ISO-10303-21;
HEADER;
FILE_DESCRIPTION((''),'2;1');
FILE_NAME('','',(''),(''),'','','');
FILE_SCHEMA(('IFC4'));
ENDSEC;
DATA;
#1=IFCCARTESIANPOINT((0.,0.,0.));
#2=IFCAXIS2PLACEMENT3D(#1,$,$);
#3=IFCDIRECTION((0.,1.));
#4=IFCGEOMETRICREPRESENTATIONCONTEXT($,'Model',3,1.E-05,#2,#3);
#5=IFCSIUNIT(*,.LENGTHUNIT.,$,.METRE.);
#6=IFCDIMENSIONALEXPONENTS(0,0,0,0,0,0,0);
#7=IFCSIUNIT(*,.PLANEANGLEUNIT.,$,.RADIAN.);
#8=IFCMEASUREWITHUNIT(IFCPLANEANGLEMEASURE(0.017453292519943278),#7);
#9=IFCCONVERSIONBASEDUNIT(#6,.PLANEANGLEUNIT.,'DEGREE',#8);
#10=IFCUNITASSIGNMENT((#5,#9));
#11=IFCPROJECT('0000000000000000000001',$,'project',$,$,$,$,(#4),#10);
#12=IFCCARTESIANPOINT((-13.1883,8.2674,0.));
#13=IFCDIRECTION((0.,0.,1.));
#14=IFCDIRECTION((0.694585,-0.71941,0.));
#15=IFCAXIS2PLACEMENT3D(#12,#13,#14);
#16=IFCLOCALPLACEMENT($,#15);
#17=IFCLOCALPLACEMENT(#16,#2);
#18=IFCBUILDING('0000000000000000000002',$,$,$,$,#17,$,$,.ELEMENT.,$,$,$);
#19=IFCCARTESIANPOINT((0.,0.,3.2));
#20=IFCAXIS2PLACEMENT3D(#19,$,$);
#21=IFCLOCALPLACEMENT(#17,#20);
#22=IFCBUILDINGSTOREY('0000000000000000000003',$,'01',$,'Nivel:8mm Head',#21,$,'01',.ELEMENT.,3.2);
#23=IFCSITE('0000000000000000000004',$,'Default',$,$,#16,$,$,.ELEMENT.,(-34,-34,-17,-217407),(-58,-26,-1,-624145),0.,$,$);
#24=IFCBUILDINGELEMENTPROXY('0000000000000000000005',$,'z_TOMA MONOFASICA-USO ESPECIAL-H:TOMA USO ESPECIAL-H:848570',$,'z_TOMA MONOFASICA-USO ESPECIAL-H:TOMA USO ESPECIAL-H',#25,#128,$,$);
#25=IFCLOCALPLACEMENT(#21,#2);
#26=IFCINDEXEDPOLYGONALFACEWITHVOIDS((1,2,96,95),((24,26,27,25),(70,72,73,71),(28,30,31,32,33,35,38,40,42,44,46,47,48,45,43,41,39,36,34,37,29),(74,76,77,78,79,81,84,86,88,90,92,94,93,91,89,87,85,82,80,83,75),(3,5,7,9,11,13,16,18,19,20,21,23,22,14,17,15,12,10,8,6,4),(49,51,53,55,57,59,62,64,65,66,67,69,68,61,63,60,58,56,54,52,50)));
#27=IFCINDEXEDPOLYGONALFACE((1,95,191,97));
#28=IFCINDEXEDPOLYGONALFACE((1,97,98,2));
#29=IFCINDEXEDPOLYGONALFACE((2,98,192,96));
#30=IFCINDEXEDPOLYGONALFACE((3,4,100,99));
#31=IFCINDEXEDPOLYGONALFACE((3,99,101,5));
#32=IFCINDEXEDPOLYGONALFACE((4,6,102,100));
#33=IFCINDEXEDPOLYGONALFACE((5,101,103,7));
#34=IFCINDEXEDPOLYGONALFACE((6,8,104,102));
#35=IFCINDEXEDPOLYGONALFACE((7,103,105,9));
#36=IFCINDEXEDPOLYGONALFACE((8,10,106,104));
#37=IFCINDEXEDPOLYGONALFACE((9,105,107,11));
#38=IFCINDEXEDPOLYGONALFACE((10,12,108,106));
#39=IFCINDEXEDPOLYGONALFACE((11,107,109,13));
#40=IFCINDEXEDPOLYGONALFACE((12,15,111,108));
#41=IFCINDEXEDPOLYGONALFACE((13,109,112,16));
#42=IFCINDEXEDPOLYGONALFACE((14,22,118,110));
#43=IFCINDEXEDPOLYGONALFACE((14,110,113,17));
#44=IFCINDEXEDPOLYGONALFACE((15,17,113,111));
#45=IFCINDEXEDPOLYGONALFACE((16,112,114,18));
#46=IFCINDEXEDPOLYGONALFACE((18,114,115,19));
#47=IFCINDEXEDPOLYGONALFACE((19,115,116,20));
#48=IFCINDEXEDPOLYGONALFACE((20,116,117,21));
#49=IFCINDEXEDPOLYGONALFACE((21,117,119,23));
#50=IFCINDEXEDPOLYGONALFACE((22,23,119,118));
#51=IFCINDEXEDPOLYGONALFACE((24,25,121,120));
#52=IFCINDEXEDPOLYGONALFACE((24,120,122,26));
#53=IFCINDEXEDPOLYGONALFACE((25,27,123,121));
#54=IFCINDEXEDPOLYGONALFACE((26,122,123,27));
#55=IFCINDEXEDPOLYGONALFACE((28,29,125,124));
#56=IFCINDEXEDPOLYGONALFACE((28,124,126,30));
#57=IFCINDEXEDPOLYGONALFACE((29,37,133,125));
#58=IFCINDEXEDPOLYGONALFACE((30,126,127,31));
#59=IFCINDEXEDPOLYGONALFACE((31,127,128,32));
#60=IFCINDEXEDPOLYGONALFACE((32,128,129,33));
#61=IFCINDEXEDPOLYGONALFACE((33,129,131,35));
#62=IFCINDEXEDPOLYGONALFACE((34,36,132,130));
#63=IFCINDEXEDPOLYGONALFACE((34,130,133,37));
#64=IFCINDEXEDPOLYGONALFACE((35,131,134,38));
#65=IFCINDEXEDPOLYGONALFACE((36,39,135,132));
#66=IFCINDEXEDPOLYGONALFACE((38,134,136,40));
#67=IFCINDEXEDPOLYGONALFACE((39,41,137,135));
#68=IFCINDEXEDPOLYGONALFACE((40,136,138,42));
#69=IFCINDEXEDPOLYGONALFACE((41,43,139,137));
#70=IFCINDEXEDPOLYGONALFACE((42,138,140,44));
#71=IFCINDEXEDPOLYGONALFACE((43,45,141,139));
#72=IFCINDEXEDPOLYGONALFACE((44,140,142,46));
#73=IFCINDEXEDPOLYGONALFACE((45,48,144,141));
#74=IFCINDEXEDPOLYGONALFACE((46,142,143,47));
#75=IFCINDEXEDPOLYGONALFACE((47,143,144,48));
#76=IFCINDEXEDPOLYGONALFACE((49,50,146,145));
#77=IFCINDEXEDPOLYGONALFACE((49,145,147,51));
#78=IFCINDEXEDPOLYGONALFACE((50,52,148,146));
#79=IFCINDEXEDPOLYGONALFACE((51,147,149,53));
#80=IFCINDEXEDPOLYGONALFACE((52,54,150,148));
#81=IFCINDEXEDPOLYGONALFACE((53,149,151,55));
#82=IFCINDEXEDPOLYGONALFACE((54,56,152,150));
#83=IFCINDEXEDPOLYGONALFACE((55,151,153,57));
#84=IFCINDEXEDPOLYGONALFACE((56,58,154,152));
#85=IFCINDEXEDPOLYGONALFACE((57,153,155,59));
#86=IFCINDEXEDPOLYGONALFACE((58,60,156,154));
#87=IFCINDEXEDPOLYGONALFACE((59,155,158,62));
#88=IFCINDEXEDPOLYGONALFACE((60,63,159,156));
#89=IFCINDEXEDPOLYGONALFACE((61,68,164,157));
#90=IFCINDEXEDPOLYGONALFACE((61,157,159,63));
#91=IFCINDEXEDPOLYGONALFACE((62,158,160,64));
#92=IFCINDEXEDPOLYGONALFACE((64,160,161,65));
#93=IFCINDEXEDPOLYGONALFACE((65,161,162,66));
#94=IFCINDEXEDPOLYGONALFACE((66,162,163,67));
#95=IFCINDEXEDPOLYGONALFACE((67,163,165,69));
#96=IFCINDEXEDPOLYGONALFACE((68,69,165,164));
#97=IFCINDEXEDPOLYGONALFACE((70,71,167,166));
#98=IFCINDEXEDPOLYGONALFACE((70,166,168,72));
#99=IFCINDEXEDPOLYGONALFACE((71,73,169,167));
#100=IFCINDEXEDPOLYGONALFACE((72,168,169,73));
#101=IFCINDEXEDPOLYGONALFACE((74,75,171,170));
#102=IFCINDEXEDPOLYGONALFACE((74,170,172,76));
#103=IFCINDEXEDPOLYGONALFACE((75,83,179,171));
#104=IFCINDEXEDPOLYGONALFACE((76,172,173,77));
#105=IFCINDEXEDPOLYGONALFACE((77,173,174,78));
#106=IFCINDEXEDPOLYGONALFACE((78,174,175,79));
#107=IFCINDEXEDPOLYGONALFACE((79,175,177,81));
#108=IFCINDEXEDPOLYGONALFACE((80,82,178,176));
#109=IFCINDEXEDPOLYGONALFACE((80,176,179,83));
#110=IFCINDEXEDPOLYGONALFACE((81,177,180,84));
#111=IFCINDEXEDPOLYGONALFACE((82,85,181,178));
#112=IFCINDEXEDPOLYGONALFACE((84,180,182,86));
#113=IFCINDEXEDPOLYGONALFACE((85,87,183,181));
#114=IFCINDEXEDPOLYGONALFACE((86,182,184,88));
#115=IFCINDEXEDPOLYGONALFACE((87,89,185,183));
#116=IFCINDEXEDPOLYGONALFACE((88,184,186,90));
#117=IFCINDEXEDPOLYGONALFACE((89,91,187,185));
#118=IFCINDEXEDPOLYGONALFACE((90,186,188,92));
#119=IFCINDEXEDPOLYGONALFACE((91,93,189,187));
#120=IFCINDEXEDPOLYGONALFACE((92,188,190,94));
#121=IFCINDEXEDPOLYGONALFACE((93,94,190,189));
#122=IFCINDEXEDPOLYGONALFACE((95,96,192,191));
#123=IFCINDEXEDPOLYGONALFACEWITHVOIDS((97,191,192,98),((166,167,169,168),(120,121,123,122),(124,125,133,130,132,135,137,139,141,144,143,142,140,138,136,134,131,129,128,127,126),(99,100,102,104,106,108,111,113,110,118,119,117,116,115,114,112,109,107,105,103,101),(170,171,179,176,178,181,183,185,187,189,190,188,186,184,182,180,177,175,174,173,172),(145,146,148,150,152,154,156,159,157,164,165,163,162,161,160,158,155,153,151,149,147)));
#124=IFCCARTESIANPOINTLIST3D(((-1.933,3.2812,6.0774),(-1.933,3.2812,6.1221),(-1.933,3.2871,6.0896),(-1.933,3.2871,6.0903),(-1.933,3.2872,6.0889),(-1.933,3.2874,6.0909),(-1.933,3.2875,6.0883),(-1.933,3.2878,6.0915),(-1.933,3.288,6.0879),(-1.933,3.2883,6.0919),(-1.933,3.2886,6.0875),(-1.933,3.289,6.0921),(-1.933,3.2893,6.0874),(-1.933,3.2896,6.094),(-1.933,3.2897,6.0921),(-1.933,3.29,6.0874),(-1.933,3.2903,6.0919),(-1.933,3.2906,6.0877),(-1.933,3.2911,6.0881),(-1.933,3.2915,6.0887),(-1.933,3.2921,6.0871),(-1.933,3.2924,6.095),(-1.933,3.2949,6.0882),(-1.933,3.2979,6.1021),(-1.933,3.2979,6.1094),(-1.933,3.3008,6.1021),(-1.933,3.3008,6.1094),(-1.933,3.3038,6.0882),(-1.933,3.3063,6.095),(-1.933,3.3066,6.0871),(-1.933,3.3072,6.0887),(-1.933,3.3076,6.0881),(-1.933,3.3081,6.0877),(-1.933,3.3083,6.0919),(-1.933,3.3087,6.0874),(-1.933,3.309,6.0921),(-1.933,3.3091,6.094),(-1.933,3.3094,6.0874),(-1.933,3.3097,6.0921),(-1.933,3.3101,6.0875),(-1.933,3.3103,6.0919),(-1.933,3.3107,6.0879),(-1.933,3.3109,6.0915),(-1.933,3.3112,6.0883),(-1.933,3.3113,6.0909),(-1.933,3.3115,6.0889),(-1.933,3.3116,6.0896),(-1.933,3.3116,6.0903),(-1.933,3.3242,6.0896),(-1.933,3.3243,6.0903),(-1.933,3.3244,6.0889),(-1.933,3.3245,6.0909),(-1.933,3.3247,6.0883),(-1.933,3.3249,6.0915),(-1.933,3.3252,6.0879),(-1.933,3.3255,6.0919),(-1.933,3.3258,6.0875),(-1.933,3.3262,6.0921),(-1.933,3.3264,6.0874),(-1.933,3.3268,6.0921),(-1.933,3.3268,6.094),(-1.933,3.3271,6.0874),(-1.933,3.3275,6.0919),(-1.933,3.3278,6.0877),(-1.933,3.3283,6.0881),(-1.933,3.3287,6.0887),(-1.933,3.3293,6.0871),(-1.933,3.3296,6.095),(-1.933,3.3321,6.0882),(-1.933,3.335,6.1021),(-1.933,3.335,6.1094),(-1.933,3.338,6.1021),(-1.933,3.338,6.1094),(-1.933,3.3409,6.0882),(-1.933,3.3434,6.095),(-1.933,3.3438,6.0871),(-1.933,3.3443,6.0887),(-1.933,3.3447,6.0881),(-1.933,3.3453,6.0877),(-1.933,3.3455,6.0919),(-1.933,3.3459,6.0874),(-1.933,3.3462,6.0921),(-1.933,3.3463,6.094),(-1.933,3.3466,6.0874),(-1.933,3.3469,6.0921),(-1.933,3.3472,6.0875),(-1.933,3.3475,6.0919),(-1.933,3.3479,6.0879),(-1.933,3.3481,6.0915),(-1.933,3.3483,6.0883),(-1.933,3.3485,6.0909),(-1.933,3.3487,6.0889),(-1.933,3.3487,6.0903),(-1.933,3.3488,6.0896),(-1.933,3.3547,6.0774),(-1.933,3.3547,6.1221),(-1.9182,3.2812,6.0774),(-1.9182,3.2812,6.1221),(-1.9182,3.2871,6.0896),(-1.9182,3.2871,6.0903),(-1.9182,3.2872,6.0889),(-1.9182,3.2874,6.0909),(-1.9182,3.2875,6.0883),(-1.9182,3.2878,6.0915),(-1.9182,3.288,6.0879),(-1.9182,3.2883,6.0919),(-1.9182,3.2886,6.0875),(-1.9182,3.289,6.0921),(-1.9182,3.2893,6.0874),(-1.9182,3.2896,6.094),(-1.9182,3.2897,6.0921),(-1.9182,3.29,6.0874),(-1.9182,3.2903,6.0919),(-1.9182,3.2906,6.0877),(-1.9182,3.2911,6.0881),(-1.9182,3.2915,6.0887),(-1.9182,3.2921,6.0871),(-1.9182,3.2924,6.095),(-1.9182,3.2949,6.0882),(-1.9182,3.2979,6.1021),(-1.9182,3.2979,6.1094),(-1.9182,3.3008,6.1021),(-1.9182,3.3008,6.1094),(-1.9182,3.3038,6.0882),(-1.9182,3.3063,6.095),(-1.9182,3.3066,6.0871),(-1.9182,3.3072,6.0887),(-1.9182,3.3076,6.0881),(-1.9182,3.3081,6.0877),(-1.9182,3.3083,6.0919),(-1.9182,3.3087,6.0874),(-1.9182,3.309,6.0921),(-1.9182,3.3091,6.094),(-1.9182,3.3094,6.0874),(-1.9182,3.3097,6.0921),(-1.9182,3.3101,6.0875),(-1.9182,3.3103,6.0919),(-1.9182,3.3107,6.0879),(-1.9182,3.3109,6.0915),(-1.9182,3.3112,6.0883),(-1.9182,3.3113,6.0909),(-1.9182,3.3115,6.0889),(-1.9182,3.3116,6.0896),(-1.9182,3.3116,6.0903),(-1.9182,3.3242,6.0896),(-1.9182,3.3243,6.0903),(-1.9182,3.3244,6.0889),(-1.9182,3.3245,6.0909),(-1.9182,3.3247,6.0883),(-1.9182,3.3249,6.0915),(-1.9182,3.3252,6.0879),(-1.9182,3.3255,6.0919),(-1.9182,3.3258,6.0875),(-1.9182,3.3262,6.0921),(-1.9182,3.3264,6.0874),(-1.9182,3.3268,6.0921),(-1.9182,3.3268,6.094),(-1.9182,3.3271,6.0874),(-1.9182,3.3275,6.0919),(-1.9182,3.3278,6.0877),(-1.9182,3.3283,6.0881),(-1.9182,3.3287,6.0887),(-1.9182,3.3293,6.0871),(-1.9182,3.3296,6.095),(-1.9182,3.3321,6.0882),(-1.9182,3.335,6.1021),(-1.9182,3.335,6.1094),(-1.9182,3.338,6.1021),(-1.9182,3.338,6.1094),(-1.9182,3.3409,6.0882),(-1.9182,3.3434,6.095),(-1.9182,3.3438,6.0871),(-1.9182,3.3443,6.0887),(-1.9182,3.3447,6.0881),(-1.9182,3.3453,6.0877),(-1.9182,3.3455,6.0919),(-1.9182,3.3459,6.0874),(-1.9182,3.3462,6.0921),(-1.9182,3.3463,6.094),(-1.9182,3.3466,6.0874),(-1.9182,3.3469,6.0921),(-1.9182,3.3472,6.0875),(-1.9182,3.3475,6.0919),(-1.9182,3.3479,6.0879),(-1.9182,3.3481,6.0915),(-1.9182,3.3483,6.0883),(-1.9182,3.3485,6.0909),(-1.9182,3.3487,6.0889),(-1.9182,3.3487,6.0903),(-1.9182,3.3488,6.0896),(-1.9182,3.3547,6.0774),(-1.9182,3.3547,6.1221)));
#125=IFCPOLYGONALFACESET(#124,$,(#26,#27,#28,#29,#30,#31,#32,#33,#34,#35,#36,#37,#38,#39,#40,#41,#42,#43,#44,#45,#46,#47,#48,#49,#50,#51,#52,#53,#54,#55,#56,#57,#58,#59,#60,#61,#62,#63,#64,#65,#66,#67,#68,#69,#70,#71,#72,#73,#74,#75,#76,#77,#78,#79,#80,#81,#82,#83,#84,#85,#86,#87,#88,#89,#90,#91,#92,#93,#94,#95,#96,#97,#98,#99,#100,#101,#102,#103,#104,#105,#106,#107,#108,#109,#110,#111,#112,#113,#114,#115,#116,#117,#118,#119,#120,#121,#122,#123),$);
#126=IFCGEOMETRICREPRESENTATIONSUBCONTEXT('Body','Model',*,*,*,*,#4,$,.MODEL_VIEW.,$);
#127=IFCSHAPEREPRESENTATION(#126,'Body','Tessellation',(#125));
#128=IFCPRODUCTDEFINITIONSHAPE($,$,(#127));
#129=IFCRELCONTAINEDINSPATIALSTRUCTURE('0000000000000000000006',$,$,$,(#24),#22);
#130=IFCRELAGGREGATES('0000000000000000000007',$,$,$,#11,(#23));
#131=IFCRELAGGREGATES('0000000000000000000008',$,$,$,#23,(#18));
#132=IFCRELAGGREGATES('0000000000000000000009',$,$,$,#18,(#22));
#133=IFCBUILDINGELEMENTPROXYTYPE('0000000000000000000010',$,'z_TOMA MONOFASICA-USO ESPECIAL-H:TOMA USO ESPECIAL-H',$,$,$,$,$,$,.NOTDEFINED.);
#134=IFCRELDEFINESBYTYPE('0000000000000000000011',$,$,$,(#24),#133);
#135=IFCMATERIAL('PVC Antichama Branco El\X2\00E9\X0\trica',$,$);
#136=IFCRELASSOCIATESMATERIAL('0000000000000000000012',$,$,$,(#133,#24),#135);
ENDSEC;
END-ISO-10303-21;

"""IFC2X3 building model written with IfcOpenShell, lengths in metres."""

from ifc_helpers import new_model, entity, si_unit, converted_unit, direction, frame, frame_2d, origin, place, context, subcontext, project, spatial, polyline, circle_curve, parameter, trimmed, segment, composite_curve, outline, extrude, source, transform, mapped, material, type_object, type_shapes, element, save


model = new_model("IFC2X3")

# Units and contexts
model_context = context("Model", 3, precision=1e-05, world=origin(), true_north=direction((0.0, 1.0)))
body_context = subcontext(model_context, "Body", "Model", "MODEL_VIEW")
ifc_project = project(units=[si_unit("LENGTHUNIT", "METRE"), converted_unit("PLANEANGLEUNIT", "DEGREE", entity("IfcPlaneAngleMeasure", 0.017453292519943278), si_unit("PLANEANGLEUNIT", "RADIAN"), dimensions=[0, 0, 0, 0, 0, 0, 0])], contexts=[model_context])

# Site, building, storey
site_placement = place(None, frame((-13.1883, 8.2674, 0.0), z_axis=(0.0, 0.0, 1.0), x_axis=(0.694585, -0.71941, 0.0)))
site = spatial("IfcSite", under=ifc_project, at=site_placement, Name="Default", CompositionType="ELEMENT", RefLatitude=(-34, -34, -17, -217407), RefLongitude=(-58, -26, -1, -624145), RefElevation=0.0)
building_placement = place(site_placement, origin())
building = spatial("IfcBuilding", under=site, at=building_placement, CompositionType="ELEMENT")
storey_placement = place(building_placement, frame((0.0, 0.0, 3.2)))
storey = spatial("IfcBuildingStorey", under=building, at=storey_placement, Name="01", ObjectType="Nivel:8mm Head", LongName="01", CompositionType="ELEMENT", Elevation=3.2)

# Building element proxy
ifc_material_1 = material(Name="PVC Antichama Branco Elétrica")
building_element_proxy_type_1 = type_object("IfcBuildingElementProxyType", Name="z_TOMA MONOFASICA-USO ESPECIAL-H:TOMA USO ESPECIAL-H", PredefinedType="NOTDEFINED", material=ifc_material_1)
shared_shape_1 = source(origin(), body_context, "Body", "SweptSolid", [
    extrude(outline(polyline([(-0.0368, -0.0223), (0.0368, -0.0223), (0.0368, 0.0223), (-0.0368, 0.0223), (-0.0368, -0.0223)]), holes=[composite_curve([segment(polyline([(0.0141, 0.0115), (0.0116, 0.0047)]), True, "CONTINUOUS"), segment(polyline([(0.0116, 0.0047), (0.0088, 0.0057)]), True, "CONTINUOUS"), segment(polyline([(0.0088, 0.0057), (0.0096, 0.0078)]), True, "CONTINUOUS"), segment(trimmed(circle_curve(frame_2d((0.0087, 0.0099), x_axis=(1.0, 0.0)), 0.0024), [parameter(27.118901)], [parameter(292.881099)], True, "PARAMETER"), False, "CONTINUOUS"), segment(polyline([(0.0108, 0.011), (0.0113, 0.0126)]), True, "CONTINUOUS"), segment(polyline([(0.0113, 0.0126), (0.0141, 0.0115)]), True, "CONTINUOUS")], self_intersect=False), composite_curve([segment(polyline([(0.0255, 0.0047), (0.023, 0.0115)]), True, "CONTINUOUS"), segment(polyline([(0.023, 0.0115), (0.0258, 0.0126)]), True, "CONTINUOUS"), segment(polyline([(0.0258, 0.0126), (0.0264, 0.011)]), True, "CONTINUOUS"), segment(trimmed(circle_curve(frame_2d((0.0285, 0.0099), x_axis=(1.0, 0.0)), 0.0024), [parameter(247.118901)], [parameter(152.881099)], True, "PARAMETER"), False, "CONTINUOUS"), segment(polyline([(0.0276, 0.0078), (0.0283, 0.0057)]), True, "CONTINUOUS"), segment(polyline([(0.0283, 0.0057), (0.0255, 0.0047)]), True, "CONTINUOUS")], self_intersect=False), polyline([(0.0201, -0.0024), (0.0201, -0.0097), (0.0171, -0.0097), (0.0171, -0.0024), (0.0201, -0.0024)]), composite_curve([segment(polyline([(-0.0141, 0.0115), (-0.0113, 0.0126)]), True, "CONTINUOUS"), segment(polyline([(-0.0113, 0.0126), (-0.0108, 0.011)]), True, "CONTINUOUS"), segment(trimmed(circle_curve(frame_2d((-0.0087, 0.0099), x_axis=(1.0, 0.0)), 0.0024), [parameter(247.118901)], [parameter(152.881099)], True, "PARAMETER"), False, "CONTINUOUS"), segment(polyline([(-0.0096, 0.0078), (-0.0088, 0.0057)]), True, "CONTINUOUS"), segment(polyline([(-0.0088, 0.0057), (-0.0116, 0.0047)]), True, "CONTINUOUS"), segment(polyline([(-0.0116, 0.0047), (-0.0141, 0.0115)]), True, "CONTINUOUS")], self_intersect=False), composite_curve([segment(polyline([(-0.0255, 0.0047), (-0.0283, 0.0057)]), True, "CONTINUOUS"), segment(polyline([(-0.0283, 0.0057), (-0.0276, 0.0078)]), True, "CONTINUOUS"), segment(trimmed(circle_curve(frame_2d((-0.0285, 0.0099), x_axis=(1.0, 0.0)), 0.0024), [parameter(27.118901)], [parameter(292.881099)], True, "PARAMETER"), False, "CONTINUOUS"), segment(polyline([(-0.0264, 0.011), (-0.0258, 0.0126)]), True, "CONTINUOUS"), segment(polyline([(-0.0258, 0.0126), (-0.023, 0.0115)]), True, "CONTINUOUS"), segment(polyline([(-0.023, 0.0115), (-0.0255, 0.0047)]), True, "CONTINUOUS")], self_intersect=False), polyline([(-0.0201, -0.0024), (-0.0171, -0.0024), (-0.0171, -0.0097), (-0.0201, -0.0097), (-0.0201, -0.0024)])]), frame((0.0, -0.005, 0.0223), z_axis=(0.0, 1.0, 0.0), x_axis=(1.0, 0.0, 0.0)), (0.0, 0.0, 1.0), 0.0148),
])
type_shapes(building_element_proxy_type_1, [shared_shape_1])
for number, where, z_axis, x_axis, name in (
    (1, (-1.928, 3.3179, 6.0774), (0.0, 0.0, 1.0), (0.0, -1.0, 0.0), "z_TOMA MONOFASICA-USO ESPECIAL-H:TOMA USO ESPECIAL-H:848570"),
):
    element("IfcBuildingElementProxy", number, at=place(storey_placement, frame(where, z_axis=z_axis, x_axis=x_axis)), inside=storey, type_object=building_element_proxy_type_1, material=ifc_material_1, Name=name, ObjectType="z_TOMA MONOFASICA-USO ESPECIAL-H:TOMA USO ESPECIAL-H", context=body_context, shape_type="MappedRepresentation", body=[
        mapped(shared_shape_1, transform((0.0, 0.0, 0.0), scale=1.0)),
    ])

save(model, "model.ifc")
